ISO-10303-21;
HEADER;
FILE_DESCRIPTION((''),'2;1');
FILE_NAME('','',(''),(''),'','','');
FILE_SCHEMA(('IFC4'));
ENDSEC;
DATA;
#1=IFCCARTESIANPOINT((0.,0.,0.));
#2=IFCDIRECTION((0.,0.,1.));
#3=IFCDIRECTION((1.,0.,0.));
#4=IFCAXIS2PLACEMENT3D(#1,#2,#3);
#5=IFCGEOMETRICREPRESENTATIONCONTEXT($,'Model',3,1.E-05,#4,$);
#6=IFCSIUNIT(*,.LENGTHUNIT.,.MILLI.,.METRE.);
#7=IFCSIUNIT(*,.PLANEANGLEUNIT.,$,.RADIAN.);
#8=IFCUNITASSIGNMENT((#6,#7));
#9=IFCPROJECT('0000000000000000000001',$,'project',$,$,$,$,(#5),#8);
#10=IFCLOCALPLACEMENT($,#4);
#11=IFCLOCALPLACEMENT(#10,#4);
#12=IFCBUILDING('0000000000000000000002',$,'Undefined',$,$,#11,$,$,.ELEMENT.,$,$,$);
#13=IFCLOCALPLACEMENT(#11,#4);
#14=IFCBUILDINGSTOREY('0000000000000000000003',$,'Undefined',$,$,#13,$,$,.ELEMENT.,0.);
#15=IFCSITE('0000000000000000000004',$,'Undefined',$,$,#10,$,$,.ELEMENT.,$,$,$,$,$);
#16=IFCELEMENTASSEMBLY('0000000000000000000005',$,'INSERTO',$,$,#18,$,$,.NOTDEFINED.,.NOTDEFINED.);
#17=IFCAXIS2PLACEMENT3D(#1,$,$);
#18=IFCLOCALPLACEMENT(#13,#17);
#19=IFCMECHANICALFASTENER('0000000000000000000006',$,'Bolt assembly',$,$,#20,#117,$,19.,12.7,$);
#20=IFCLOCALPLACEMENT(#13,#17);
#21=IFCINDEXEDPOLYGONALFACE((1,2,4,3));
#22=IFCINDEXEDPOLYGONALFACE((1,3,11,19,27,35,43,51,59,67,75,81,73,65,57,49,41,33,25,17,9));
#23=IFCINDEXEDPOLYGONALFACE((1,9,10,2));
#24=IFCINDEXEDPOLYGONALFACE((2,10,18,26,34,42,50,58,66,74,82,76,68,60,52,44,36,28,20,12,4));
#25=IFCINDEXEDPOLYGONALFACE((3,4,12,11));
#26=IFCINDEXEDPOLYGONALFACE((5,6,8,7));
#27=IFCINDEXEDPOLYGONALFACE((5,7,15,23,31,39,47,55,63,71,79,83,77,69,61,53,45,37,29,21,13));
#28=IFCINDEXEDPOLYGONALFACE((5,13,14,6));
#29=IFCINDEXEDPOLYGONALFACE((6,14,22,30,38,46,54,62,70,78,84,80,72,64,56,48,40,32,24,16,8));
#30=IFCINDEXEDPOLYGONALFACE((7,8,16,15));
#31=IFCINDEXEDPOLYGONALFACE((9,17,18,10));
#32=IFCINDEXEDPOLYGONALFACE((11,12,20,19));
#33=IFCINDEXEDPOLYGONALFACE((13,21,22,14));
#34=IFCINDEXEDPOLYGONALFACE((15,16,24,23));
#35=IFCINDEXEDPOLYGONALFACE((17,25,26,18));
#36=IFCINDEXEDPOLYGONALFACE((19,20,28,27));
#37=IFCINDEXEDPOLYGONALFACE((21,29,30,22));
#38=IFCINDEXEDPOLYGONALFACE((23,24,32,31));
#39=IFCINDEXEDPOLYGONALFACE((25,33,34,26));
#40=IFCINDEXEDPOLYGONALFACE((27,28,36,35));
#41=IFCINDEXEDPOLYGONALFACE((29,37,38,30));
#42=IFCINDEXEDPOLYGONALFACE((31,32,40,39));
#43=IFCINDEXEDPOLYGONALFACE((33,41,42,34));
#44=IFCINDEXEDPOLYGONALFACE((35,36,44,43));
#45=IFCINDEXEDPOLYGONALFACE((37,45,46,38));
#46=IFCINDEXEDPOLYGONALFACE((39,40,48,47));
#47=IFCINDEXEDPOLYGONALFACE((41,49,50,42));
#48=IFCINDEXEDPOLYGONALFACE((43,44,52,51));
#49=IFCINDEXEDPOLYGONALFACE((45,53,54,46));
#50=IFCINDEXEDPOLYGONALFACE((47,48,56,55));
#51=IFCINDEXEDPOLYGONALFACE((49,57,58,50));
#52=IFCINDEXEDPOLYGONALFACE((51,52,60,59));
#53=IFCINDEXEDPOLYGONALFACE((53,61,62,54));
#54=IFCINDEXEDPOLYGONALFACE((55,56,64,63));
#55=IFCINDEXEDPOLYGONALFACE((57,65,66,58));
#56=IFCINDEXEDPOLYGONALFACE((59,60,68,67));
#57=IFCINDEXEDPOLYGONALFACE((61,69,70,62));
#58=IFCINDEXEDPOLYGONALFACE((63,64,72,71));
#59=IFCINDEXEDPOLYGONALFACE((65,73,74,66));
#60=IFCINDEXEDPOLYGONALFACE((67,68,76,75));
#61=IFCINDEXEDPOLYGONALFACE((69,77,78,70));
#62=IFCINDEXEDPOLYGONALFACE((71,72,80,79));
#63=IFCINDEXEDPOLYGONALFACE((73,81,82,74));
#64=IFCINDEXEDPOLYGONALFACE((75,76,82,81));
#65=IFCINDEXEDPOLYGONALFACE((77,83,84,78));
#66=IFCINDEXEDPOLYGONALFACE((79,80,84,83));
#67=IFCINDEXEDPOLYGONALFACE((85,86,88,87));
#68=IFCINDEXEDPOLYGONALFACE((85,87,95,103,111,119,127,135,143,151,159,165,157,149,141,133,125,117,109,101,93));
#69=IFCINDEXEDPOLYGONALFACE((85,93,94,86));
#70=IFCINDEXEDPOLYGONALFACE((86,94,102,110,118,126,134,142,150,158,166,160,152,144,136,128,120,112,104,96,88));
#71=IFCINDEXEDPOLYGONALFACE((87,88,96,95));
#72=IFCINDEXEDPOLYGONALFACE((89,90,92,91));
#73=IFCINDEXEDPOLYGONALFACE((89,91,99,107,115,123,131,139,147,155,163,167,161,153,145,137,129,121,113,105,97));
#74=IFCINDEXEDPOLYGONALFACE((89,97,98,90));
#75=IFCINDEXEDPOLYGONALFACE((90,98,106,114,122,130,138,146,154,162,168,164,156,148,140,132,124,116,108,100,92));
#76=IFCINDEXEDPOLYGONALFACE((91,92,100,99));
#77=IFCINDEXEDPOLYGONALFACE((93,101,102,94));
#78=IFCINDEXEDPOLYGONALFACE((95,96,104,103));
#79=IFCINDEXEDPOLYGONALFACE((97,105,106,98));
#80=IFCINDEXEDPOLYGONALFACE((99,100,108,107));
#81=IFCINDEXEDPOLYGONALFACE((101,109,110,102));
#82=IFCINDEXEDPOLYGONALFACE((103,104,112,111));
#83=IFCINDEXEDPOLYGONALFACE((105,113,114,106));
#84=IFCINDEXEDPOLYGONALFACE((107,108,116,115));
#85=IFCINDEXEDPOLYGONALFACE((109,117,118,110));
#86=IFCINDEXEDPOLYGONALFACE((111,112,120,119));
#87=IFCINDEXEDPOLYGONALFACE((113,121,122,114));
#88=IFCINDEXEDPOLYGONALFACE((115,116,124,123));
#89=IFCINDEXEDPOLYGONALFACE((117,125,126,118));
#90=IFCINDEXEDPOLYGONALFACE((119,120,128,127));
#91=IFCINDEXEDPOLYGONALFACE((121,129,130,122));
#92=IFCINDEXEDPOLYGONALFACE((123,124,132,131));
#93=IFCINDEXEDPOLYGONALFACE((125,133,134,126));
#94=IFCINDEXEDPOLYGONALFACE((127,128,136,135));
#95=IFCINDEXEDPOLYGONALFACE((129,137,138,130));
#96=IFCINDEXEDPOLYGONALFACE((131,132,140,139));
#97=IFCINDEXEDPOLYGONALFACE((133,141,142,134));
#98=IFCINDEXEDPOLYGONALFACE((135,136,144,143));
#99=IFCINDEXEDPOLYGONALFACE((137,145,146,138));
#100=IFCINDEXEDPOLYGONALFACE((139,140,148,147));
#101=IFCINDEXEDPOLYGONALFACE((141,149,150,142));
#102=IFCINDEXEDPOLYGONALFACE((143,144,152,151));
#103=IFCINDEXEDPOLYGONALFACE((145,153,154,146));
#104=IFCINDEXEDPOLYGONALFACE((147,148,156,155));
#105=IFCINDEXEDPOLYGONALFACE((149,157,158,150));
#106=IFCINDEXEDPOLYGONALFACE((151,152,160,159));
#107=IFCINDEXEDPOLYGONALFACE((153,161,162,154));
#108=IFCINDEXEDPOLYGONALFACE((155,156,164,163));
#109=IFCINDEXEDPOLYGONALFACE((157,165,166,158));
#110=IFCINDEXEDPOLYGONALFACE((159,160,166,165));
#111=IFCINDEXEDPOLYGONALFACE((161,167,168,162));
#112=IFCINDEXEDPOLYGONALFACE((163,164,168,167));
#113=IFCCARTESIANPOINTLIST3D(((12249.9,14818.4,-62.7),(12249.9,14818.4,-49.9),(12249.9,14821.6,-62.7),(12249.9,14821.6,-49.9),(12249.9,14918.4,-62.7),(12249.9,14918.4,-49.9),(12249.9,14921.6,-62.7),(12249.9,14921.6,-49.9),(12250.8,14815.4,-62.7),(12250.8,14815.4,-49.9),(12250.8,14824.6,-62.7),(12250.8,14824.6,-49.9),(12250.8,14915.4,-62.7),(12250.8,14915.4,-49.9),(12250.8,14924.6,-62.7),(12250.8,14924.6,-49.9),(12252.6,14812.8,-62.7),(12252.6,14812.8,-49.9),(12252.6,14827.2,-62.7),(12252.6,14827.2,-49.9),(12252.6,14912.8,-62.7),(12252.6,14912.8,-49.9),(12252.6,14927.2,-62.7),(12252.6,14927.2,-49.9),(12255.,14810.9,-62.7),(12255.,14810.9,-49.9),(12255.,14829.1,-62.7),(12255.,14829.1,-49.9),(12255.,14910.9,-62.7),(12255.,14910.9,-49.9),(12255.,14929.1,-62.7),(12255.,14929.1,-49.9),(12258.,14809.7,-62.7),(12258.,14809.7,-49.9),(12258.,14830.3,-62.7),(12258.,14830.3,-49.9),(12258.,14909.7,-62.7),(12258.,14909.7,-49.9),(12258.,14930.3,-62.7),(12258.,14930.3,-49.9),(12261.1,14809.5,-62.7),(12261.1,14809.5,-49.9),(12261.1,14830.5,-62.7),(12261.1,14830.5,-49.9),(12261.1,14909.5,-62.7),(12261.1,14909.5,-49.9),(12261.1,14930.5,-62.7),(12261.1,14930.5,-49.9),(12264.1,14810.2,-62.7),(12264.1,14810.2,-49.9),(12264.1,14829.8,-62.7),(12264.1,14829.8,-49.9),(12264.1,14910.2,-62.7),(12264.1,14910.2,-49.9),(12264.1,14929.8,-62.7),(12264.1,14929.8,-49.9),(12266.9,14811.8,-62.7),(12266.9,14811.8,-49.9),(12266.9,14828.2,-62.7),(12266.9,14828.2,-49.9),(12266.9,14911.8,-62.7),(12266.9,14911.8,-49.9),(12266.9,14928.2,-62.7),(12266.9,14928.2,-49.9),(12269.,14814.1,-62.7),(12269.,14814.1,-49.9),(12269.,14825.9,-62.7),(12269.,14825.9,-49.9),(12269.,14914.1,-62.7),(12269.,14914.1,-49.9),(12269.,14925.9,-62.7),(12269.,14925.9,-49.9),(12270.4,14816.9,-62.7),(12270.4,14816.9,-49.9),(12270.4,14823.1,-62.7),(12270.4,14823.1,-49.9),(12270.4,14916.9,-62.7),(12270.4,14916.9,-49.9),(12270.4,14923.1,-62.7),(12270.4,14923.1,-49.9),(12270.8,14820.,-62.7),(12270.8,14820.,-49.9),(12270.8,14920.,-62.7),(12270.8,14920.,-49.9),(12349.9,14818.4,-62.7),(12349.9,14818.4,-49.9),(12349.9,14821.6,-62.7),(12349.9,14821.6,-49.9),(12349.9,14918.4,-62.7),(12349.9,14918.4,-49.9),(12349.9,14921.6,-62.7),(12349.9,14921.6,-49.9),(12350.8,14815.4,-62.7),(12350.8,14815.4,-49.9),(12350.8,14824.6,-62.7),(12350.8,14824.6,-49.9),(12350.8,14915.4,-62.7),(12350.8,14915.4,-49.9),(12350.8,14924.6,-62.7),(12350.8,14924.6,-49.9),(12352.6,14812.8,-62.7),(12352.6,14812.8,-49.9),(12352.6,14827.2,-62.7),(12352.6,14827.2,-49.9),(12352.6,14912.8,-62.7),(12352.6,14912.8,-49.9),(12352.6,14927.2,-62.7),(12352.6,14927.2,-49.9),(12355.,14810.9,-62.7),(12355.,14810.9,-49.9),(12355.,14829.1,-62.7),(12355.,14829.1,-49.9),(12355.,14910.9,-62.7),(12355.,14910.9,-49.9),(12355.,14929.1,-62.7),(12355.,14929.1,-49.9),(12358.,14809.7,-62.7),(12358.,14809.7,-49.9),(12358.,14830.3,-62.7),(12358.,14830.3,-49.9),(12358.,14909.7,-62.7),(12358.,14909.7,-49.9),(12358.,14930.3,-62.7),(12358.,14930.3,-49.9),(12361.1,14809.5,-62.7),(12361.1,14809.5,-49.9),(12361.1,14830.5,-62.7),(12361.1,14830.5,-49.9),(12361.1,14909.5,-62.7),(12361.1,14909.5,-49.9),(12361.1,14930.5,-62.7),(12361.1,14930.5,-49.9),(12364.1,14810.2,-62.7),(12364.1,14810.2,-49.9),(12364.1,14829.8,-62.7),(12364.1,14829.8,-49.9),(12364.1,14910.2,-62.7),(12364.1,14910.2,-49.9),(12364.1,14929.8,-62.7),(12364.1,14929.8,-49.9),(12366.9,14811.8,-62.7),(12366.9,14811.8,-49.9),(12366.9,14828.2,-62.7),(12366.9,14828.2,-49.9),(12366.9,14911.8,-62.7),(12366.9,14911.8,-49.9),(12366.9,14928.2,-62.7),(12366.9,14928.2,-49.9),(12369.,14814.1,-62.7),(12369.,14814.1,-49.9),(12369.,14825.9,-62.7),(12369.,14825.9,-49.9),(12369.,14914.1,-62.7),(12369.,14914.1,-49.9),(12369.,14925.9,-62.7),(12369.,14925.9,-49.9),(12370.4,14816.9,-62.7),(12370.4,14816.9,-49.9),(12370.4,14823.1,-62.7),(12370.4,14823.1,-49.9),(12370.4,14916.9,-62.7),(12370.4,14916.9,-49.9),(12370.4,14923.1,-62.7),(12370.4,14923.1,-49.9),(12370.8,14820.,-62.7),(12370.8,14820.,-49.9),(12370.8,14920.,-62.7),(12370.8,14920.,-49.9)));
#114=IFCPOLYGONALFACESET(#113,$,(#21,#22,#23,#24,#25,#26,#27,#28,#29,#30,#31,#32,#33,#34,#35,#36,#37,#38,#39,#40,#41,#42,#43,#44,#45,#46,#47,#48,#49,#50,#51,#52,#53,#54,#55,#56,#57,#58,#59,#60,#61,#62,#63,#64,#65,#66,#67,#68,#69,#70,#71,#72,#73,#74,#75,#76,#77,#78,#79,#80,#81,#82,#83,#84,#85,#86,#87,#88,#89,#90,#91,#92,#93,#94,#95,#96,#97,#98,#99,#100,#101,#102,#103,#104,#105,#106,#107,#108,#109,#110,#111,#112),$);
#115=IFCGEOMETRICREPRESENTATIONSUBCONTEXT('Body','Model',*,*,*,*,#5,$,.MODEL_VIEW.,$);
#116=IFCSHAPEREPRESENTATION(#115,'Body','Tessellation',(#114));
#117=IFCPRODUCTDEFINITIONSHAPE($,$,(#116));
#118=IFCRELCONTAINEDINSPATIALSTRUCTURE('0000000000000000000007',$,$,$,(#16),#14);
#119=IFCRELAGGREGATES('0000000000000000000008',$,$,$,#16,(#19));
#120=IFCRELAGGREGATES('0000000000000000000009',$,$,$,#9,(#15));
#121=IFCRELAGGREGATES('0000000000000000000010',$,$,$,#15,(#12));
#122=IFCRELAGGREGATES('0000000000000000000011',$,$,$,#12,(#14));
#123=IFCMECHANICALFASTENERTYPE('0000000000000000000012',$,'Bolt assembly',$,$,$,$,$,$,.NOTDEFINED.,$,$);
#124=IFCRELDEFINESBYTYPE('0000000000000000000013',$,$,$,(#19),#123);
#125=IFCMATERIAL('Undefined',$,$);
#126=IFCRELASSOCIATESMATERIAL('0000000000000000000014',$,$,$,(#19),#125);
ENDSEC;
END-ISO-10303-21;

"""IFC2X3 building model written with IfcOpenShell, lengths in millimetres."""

from ifc_helpers import new_model, si_unit, frame, origin_with_axes, origin_2d_with_axis, place, context, subcontext, project, spatial, circle, extrude, source, transform, mapped, material, type_object, element, aggregate, save


model = new_model("IFC2X3")

# Units and contexts
model_context = context("Model", 3, precision=1e-05, world=origin_with_axes())
body_context = subcontext(model_context, "Body", "Model", "MODEL_VIEW")
ifc_project = project(units=[si_unit("LENGTHUNIT", "METRE", prefix="MILLI"), si_unit("PLANEANGLEUNIT", "RADIAN")], contexts=[model_context])

# Site, building, storey
site_placement = place(None, origin_with_axes())
site = spatial("IfcSite", under=ifc_project, at=site_placement, Name="Undefined", CompositionType="ELEMENT")
building_placement = place(site_placement, origin_with_axes())
building = spatial("IfcBuilding", under=site, at=building_placement, Name="Undefined", CompositionType="ELEMENT")
storey_placement = place(building_placement, origin_with_axes())
storey = spatial("IfcBuildingStorey", under=building, at=storey_placement, Name="Undefined", CompositionType="ELEMENT", Elevation=0.0)

# Element assembly
assembly_1_placement = place(storey_placement, origin_with_axes())
assembly_1 = element("IfcElementAssembly", 1, at=assembly_1_placement, inside=storey, Name="INSERTO", AssemblyPlace="NOTDEFINED", PredefinedType="NOTDEFINED")

# Shared definitions
ifc_material_1 = material(Name="Undefined")
mechanical_fastener_type = type_object("IfcMechanicalFastenerType", Name="Bolt assembly")

# Mechanical fastener
shared_shape_1 = source(origin_with_axes(), body_context, "Body", "SweptSolid", [
    extrude(circle(Radius=10.5, at=origin_2d_with_axis()), frame((0.0, -6.4, 0.0), z_axis=(0.0, 1.0, 0.0), x_axis=(1.0, 0.0, 0.0)), (0.0, 0.0, 1.0), 12.8),
])
mechanical_fastener_1_placement = place(assembly_1_placement, frame((12260.3, 14870.0, -56.3), z_axis=(0.0, -1.0, 0.0), x_axis=(1.0, 0.0, 0.0)))
mechanical_fastener_1 = element("IfcMechanicalFastener", 2, at=mechanical_fastener_1_placement, type_object=mechanical_fastener_type, material=ifc_material_1, Name="Bolt assembly", NominalDiameter=19.0, NominalLength=12.7, context=body_context, shape_type="MappedRepresentation", body=[
    mapped(shared_shape_1, transform((0.0, 0.0, -50.0))),
    mapped(shared_shape_1, transform((100.0, 0.0, -50.0))),
    mapped(shared_shape_1, transform((0.0, 0.0, 50.0))),
    mapped(shared_shape_1, transform((100.0, 0.0, 50.0))),
])
aggregate(assembly_1, [mechanical_fastener_1])

save(model, "model.ifc")
